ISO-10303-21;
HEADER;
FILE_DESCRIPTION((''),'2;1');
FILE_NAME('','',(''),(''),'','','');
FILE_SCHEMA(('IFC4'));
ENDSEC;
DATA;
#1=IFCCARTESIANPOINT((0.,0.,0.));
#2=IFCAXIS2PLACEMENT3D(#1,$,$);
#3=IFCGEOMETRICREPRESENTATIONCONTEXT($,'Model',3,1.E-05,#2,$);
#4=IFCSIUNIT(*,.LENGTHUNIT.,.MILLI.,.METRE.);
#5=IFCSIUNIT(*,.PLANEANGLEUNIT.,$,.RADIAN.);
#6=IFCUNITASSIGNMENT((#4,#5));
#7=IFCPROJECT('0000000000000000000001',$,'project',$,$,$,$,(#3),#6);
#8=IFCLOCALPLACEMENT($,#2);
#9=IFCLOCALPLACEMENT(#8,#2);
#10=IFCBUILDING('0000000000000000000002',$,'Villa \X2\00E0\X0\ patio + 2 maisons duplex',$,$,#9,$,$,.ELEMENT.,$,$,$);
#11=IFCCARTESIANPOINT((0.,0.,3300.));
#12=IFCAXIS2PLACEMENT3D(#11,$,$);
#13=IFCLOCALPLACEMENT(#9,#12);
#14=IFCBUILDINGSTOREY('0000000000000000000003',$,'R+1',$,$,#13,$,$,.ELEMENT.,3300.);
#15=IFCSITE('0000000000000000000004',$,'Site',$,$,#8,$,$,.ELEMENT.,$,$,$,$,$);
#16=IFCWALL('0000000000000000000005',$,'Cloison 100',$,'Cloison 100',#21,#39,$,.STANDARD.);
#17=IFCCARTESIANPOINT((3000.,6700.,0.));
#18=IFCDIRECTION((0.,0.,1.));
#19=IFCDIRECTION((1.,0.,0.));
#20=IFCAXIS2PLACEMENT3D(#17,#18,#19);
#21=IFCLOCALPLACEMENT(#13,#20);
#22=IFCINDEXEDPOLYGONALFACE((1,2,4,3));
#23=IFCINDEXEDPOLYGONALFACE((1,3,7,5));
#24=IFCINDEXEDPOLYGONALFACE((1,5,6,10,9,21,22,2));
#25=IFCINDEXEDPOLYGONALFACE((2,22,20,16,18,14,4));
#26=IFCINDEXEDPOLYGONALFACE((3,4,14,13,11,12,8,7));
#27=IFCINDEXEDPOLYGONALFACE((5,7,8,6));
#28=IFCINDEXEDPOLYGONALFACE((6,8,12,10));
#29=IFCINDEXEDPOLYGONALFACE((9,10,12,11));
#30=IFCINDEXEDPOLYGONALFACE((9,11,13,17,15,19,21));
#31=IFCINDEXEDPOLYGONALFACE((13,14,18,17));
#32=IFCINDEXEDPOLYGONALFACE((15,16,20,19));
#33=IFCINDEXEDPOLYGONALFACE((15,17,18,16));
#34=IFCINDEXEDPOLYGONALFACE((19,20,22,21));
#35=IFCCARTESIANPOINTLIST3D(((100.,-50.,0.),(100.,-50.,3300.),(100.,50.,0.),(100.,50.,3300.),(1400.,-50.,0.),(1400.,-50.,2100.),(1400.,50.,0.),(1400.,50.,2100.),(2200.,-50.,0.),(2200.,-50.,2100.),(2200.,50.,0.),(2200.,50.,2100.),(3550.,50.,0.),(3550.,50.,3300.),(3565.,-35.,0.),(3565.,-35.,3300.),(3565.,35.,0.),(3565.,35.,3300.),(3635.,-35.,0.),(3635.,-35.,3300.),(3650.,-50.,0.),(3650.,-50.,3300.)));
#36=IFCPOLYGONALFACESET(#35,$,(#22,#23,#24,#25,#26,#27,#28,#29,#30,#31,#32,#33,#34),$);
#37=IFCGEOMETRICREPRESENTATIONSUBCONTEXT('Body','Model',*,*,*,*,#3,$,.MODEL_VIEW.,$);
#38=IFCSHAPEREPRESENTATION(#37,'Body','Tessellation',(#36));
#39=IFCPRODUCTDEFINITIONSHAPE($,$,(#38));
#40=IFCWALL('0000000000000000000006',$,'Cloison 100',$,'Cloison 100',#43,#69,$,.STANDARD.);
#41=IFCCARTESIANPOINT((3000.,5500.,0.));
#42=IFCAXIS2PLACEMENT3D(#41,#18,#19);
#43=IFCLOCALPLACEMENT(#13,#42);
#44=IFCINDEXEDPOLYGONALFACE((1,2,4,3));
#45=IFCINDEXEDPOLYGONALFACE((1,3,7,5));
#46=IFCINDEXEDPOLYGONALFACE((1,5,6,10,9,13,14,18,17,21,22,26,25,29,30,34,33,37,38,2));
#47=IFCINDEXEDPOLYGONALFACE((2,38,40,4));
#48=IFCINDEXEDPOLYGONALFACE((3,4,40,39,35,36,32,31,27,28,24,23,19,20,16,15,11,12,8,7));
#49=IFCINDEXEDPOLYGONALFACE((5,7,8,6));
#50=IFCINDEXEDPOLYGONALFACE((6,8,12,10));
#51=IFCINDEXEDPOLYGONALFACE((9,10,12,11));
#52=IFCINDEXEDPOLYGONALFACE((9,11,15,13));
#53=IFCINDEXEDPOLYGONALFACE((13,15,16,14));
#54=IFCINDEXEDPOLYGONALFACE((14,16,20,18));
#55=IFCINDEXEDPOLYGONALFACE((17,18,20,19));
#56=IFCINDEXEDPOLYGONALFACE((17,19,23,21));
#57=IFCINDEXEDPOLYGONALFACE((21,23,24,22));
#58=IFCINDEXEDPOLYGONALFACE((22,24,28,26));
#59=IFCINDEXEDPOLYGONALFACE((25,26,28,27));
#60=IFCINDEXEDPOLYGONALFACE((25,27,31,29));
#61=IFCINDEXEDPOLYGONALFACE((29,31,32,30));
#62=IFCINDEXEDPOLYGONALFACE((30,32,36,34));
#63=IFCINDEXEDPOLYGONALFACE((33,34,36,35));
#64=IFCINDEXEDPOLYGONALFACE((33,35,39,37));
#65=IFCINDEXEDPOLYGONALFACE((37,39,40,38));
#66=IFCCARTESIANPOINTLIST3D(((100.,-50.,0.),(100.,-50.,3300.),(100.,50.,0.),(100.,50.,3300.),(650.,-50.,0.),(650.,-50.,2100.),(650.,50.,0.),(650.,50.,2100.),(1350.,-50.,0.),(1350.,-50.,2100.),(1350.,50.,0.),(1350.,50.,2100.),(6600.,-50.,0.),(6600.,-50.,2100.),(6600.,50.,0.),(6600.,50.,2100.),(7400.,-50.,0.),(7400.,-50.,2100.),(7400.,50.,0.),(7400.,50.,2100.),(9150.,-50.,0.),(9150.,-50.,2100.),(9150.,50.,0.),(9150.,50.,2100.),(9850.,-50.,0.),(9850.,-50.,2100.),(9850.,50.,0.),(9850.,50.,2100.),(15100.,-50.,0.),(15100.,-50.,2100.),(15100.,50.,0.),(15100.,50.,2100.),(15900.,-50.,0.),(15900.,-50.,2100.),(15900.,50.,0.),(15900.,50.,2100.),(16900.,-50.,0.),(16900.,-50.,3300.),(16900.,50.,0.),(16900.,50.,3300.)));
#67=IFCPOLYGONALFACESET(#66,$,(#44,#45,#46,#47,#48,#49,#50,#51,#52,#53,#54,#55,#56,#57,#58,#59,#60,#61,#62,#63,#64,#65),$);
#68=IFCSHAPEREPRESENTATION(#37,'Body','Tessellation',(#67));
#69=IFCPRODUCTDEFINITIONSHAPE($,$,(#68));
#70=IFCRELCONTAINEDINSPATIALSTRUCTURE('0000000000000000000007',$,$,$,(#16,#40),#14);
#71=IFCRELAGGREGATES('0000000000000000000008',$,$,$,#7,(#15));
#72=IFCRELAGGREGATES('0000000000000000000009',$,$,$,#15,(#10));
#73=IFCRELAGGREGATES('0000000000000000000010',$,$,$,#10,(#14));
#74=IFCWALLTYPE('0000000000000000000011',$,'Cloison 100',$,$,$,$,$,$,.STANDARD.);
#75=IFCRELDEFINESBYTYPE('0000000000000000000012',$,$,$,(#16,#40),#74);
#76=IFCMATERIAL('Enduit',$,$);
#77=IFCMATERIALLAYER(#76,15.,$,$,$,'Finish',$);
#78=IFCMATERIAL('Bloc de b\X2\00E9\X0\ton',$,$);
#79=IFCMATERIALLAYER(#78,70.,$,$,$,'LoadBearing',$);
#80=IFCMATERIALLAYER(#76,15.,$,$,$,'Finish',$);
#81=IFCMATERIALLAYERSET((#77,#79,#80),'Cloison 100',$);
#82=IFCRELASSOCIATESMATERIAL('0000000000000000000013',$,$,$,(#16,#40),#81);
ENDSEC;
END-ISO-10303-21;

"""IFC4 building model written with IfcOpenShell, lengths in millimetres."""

from ifc_helpers import new_model, si_unit, frame, frame_2d, origin, place, context, subcontext, project, spatial, polyline, rectangle, outline, extrude, material, layer, layer_set, layer_usage, type_object, element, save


model = new_model("IFC4")

# Units and contexts
model_context = context("Model", 3, precision=1e-05, world=origin())
body_context = subcontext(model_context, "Body", "Model", "MODEL_VIEW")
ifc_project = project(units=[si_unit("LENGTHUNIT", "METRE", prefix="MILLI"), si_unit("PLANEANGLEUNIT", "RADIAN")], contexts=[model_context])

# Site, building, storey
site_placement = place(None, origin())
site = spatial("IfcSite", under=ifc_project, at=site_placement, Name="Site", CompositionType="ELEMENT")
building_placement = place(site_placement, origin())
building = spatial("IfcBuilding", under=site, at=building_placement, Name="Villa à patio + 2 maisons duplex", CompositionType="ELEMENT")
storey_placement = place(building_placement, frame((0.0, 0.0, 3300.0)))
storey = spatial("IfcBuildingStorey", under=building, at=storey_placement, Name="R+1", CompositionType="ELEMENT", Elevation=3300.0)

# Wall, opening
ifc_material_1 = material(Name="Enduit")
ifc_layer_1 = layer(ifc_material_1, 15.0, Category="Finish")
ifc_material_2 = material(Name="Bloc de béton")
ifc_layer_2 = layer(ifc_material_2, 70.0, Category="LoadBearing")
ifc_layer_3 = layer(ifc_material_1, 15.0, Category="Finish")
ifc_layer_set_1 = layer_set([ifc_layer_1, ifc_layer_2, ifc_layer_3], Name="Cloison 100")
ifc_layer_usage_1 = layer_usage(ifc_layer_set_1, "AXIS2", "NEGATIVE", 50.0)
wall_type_1 = type_object("IfcWallType", Name="Cloison 100", PredefinedType="STANDARD")
wall_1_placement = place(storey_placement, frame((3000.0, 6700.0, 0.0), z_axis=(0.0, 0.0, 1.0), x_axis=(1.0, 0.0, 0.0)))
wall_1 = element("IfcWall", 1, at=wall_1_placement, inside=storey, type_object=wall_type_1, material=ifc_layer_usage_1, Name="Cloison 100", ObjectType="Cloison 100", PredefinedType="STANDARD", context=body_context, shape_type="SweptSolid", body=[
    extrude(outline(polyline([(100.0, -50.0), (100.0, 50.0), (3550.0, 50.0), (3565.0, 35.0), (3565.0, -35.0), (3635.0, -35.0), (3650.0, -50.0), (100.0, -50.0)])), origin(), (0.0, 0.0, 1.0), 3300.0),
])
opening_1_placement = place(wall_1_placement, frame((1400.0, 0.0, 0.0), z_axis=(0.0, 0.0, 1.0), x_axis=(1.0, 0.0, 0.0)))
element("IfcOpeningElement", 2, at=opening_1_placement, cuts=wall_1, PredefinedType="OPENING", context=body_context, shape_type="SweptSolid", body=[
    extrude(rectangle(XDim=800.0, YDim=120.0, at=frame_2d((400.0, 0.0))), origin(), (0.0, 0.0, 1.0), 2100.0),
])

# Wall, openings
wall_2_placement = place(storey_placement, frame((3000.0, 5500.0, 0.0), z_axis=(0.0, 0.0, 1.0), x_axis=(1.0, 0.0, 0.0)))
wall_2 = element("IfcWall", 3, at=wall_2_placement, inside=storey, type_object=wall_type_1, material=ifc_layer_usage_1, Name="Cloison 100", ObjectType="Cloison 100", PredefinedType="STANDARD", context=body_context, shape_type="SweptSolid", body=[
    extrude(outline(polyline([(100.0, -50.0), (100.0, 50.0), (16900.0, 50.0), (16900.0, -50.0), (100.0, -50.0)])), origin(), (0.0, 0.0, 1.0), 3300.0),
])
opening_2_placement = place(wall_2_placement, frame((6600.0, 0.0, 0.0), z_axis=(0.0, 0.0, 1.0), x_axis=(1.0, 0.0, 0.0)))
element("IfcOpeningElement", 4, at=opening_2_placement, cuts=wall_2, PredefinedType="OPENING", context=body_context, shape_type="SweptSolid", body=[
    extrude(rectangle(XDim=800.0, YDim=120.0, at=frame_2d((400.0, 0.0))), origin(), (0.0, 0.0, 1.0), 2100.0),
])
opening_3_placement = place(wall_2_placement, frame((650.0, 0.0, 0.0), z_axis=(0.0, 0.0, 1.0), x_axis=(1.0, 0.0, 0.0)))
element("IfcOpeningElement", 5, at=opening_3_placement, cuts=wall_2, PredefinedType="OPENING", context=body_context, shape_type="SweptSolid", body=[
    extrude(rectangle(XDim=700.0, YDim=120.0, at=frame_2d((350.0, 0.0))), origin(), (0.0, 0.0, 1.0), 2100.0),
])
opening_4_placement = place(wall_2_placement, frame((15100.0, 0.0, 0.0), z_axis=(0.0, 0.0, 1.0), x_axis=(1.0, 0.0, 0.0)))
element("IfcOpeningElement", 6, at=opening_4_placement, cuts=wall_2, PredefinedType="OPENING", context=body_context, shape_type="SweptSolid", body=[
    extrude(rectangle(XDim=800.0, YDim=120.0, at=frame_2d((400.0, 0.0))), origin(), (0.0, 0.0, 1.0), 2100.0),
])
opening_5_placement = place(wall_2_placement, frame((9150.0, 0.0, 0.0), z_axis=(0.0, 0.0, 1.0), x_axis=(1.0, 0.0, 0.0)))
element("IfcOpeningElement", 7, at=opening_5_placement, cuts=wall_2, PredefinedType="OPENING", context=body_context, shape_type="SweptSolid", body=[
    extrude(rectangle(XDim=700.0, YDim=120.0, at=frame_2d((350.0, 0.0))), origin(), (0.0, 0.0, 1.0), 2100.0),
])

save(model, "model.ifc")
